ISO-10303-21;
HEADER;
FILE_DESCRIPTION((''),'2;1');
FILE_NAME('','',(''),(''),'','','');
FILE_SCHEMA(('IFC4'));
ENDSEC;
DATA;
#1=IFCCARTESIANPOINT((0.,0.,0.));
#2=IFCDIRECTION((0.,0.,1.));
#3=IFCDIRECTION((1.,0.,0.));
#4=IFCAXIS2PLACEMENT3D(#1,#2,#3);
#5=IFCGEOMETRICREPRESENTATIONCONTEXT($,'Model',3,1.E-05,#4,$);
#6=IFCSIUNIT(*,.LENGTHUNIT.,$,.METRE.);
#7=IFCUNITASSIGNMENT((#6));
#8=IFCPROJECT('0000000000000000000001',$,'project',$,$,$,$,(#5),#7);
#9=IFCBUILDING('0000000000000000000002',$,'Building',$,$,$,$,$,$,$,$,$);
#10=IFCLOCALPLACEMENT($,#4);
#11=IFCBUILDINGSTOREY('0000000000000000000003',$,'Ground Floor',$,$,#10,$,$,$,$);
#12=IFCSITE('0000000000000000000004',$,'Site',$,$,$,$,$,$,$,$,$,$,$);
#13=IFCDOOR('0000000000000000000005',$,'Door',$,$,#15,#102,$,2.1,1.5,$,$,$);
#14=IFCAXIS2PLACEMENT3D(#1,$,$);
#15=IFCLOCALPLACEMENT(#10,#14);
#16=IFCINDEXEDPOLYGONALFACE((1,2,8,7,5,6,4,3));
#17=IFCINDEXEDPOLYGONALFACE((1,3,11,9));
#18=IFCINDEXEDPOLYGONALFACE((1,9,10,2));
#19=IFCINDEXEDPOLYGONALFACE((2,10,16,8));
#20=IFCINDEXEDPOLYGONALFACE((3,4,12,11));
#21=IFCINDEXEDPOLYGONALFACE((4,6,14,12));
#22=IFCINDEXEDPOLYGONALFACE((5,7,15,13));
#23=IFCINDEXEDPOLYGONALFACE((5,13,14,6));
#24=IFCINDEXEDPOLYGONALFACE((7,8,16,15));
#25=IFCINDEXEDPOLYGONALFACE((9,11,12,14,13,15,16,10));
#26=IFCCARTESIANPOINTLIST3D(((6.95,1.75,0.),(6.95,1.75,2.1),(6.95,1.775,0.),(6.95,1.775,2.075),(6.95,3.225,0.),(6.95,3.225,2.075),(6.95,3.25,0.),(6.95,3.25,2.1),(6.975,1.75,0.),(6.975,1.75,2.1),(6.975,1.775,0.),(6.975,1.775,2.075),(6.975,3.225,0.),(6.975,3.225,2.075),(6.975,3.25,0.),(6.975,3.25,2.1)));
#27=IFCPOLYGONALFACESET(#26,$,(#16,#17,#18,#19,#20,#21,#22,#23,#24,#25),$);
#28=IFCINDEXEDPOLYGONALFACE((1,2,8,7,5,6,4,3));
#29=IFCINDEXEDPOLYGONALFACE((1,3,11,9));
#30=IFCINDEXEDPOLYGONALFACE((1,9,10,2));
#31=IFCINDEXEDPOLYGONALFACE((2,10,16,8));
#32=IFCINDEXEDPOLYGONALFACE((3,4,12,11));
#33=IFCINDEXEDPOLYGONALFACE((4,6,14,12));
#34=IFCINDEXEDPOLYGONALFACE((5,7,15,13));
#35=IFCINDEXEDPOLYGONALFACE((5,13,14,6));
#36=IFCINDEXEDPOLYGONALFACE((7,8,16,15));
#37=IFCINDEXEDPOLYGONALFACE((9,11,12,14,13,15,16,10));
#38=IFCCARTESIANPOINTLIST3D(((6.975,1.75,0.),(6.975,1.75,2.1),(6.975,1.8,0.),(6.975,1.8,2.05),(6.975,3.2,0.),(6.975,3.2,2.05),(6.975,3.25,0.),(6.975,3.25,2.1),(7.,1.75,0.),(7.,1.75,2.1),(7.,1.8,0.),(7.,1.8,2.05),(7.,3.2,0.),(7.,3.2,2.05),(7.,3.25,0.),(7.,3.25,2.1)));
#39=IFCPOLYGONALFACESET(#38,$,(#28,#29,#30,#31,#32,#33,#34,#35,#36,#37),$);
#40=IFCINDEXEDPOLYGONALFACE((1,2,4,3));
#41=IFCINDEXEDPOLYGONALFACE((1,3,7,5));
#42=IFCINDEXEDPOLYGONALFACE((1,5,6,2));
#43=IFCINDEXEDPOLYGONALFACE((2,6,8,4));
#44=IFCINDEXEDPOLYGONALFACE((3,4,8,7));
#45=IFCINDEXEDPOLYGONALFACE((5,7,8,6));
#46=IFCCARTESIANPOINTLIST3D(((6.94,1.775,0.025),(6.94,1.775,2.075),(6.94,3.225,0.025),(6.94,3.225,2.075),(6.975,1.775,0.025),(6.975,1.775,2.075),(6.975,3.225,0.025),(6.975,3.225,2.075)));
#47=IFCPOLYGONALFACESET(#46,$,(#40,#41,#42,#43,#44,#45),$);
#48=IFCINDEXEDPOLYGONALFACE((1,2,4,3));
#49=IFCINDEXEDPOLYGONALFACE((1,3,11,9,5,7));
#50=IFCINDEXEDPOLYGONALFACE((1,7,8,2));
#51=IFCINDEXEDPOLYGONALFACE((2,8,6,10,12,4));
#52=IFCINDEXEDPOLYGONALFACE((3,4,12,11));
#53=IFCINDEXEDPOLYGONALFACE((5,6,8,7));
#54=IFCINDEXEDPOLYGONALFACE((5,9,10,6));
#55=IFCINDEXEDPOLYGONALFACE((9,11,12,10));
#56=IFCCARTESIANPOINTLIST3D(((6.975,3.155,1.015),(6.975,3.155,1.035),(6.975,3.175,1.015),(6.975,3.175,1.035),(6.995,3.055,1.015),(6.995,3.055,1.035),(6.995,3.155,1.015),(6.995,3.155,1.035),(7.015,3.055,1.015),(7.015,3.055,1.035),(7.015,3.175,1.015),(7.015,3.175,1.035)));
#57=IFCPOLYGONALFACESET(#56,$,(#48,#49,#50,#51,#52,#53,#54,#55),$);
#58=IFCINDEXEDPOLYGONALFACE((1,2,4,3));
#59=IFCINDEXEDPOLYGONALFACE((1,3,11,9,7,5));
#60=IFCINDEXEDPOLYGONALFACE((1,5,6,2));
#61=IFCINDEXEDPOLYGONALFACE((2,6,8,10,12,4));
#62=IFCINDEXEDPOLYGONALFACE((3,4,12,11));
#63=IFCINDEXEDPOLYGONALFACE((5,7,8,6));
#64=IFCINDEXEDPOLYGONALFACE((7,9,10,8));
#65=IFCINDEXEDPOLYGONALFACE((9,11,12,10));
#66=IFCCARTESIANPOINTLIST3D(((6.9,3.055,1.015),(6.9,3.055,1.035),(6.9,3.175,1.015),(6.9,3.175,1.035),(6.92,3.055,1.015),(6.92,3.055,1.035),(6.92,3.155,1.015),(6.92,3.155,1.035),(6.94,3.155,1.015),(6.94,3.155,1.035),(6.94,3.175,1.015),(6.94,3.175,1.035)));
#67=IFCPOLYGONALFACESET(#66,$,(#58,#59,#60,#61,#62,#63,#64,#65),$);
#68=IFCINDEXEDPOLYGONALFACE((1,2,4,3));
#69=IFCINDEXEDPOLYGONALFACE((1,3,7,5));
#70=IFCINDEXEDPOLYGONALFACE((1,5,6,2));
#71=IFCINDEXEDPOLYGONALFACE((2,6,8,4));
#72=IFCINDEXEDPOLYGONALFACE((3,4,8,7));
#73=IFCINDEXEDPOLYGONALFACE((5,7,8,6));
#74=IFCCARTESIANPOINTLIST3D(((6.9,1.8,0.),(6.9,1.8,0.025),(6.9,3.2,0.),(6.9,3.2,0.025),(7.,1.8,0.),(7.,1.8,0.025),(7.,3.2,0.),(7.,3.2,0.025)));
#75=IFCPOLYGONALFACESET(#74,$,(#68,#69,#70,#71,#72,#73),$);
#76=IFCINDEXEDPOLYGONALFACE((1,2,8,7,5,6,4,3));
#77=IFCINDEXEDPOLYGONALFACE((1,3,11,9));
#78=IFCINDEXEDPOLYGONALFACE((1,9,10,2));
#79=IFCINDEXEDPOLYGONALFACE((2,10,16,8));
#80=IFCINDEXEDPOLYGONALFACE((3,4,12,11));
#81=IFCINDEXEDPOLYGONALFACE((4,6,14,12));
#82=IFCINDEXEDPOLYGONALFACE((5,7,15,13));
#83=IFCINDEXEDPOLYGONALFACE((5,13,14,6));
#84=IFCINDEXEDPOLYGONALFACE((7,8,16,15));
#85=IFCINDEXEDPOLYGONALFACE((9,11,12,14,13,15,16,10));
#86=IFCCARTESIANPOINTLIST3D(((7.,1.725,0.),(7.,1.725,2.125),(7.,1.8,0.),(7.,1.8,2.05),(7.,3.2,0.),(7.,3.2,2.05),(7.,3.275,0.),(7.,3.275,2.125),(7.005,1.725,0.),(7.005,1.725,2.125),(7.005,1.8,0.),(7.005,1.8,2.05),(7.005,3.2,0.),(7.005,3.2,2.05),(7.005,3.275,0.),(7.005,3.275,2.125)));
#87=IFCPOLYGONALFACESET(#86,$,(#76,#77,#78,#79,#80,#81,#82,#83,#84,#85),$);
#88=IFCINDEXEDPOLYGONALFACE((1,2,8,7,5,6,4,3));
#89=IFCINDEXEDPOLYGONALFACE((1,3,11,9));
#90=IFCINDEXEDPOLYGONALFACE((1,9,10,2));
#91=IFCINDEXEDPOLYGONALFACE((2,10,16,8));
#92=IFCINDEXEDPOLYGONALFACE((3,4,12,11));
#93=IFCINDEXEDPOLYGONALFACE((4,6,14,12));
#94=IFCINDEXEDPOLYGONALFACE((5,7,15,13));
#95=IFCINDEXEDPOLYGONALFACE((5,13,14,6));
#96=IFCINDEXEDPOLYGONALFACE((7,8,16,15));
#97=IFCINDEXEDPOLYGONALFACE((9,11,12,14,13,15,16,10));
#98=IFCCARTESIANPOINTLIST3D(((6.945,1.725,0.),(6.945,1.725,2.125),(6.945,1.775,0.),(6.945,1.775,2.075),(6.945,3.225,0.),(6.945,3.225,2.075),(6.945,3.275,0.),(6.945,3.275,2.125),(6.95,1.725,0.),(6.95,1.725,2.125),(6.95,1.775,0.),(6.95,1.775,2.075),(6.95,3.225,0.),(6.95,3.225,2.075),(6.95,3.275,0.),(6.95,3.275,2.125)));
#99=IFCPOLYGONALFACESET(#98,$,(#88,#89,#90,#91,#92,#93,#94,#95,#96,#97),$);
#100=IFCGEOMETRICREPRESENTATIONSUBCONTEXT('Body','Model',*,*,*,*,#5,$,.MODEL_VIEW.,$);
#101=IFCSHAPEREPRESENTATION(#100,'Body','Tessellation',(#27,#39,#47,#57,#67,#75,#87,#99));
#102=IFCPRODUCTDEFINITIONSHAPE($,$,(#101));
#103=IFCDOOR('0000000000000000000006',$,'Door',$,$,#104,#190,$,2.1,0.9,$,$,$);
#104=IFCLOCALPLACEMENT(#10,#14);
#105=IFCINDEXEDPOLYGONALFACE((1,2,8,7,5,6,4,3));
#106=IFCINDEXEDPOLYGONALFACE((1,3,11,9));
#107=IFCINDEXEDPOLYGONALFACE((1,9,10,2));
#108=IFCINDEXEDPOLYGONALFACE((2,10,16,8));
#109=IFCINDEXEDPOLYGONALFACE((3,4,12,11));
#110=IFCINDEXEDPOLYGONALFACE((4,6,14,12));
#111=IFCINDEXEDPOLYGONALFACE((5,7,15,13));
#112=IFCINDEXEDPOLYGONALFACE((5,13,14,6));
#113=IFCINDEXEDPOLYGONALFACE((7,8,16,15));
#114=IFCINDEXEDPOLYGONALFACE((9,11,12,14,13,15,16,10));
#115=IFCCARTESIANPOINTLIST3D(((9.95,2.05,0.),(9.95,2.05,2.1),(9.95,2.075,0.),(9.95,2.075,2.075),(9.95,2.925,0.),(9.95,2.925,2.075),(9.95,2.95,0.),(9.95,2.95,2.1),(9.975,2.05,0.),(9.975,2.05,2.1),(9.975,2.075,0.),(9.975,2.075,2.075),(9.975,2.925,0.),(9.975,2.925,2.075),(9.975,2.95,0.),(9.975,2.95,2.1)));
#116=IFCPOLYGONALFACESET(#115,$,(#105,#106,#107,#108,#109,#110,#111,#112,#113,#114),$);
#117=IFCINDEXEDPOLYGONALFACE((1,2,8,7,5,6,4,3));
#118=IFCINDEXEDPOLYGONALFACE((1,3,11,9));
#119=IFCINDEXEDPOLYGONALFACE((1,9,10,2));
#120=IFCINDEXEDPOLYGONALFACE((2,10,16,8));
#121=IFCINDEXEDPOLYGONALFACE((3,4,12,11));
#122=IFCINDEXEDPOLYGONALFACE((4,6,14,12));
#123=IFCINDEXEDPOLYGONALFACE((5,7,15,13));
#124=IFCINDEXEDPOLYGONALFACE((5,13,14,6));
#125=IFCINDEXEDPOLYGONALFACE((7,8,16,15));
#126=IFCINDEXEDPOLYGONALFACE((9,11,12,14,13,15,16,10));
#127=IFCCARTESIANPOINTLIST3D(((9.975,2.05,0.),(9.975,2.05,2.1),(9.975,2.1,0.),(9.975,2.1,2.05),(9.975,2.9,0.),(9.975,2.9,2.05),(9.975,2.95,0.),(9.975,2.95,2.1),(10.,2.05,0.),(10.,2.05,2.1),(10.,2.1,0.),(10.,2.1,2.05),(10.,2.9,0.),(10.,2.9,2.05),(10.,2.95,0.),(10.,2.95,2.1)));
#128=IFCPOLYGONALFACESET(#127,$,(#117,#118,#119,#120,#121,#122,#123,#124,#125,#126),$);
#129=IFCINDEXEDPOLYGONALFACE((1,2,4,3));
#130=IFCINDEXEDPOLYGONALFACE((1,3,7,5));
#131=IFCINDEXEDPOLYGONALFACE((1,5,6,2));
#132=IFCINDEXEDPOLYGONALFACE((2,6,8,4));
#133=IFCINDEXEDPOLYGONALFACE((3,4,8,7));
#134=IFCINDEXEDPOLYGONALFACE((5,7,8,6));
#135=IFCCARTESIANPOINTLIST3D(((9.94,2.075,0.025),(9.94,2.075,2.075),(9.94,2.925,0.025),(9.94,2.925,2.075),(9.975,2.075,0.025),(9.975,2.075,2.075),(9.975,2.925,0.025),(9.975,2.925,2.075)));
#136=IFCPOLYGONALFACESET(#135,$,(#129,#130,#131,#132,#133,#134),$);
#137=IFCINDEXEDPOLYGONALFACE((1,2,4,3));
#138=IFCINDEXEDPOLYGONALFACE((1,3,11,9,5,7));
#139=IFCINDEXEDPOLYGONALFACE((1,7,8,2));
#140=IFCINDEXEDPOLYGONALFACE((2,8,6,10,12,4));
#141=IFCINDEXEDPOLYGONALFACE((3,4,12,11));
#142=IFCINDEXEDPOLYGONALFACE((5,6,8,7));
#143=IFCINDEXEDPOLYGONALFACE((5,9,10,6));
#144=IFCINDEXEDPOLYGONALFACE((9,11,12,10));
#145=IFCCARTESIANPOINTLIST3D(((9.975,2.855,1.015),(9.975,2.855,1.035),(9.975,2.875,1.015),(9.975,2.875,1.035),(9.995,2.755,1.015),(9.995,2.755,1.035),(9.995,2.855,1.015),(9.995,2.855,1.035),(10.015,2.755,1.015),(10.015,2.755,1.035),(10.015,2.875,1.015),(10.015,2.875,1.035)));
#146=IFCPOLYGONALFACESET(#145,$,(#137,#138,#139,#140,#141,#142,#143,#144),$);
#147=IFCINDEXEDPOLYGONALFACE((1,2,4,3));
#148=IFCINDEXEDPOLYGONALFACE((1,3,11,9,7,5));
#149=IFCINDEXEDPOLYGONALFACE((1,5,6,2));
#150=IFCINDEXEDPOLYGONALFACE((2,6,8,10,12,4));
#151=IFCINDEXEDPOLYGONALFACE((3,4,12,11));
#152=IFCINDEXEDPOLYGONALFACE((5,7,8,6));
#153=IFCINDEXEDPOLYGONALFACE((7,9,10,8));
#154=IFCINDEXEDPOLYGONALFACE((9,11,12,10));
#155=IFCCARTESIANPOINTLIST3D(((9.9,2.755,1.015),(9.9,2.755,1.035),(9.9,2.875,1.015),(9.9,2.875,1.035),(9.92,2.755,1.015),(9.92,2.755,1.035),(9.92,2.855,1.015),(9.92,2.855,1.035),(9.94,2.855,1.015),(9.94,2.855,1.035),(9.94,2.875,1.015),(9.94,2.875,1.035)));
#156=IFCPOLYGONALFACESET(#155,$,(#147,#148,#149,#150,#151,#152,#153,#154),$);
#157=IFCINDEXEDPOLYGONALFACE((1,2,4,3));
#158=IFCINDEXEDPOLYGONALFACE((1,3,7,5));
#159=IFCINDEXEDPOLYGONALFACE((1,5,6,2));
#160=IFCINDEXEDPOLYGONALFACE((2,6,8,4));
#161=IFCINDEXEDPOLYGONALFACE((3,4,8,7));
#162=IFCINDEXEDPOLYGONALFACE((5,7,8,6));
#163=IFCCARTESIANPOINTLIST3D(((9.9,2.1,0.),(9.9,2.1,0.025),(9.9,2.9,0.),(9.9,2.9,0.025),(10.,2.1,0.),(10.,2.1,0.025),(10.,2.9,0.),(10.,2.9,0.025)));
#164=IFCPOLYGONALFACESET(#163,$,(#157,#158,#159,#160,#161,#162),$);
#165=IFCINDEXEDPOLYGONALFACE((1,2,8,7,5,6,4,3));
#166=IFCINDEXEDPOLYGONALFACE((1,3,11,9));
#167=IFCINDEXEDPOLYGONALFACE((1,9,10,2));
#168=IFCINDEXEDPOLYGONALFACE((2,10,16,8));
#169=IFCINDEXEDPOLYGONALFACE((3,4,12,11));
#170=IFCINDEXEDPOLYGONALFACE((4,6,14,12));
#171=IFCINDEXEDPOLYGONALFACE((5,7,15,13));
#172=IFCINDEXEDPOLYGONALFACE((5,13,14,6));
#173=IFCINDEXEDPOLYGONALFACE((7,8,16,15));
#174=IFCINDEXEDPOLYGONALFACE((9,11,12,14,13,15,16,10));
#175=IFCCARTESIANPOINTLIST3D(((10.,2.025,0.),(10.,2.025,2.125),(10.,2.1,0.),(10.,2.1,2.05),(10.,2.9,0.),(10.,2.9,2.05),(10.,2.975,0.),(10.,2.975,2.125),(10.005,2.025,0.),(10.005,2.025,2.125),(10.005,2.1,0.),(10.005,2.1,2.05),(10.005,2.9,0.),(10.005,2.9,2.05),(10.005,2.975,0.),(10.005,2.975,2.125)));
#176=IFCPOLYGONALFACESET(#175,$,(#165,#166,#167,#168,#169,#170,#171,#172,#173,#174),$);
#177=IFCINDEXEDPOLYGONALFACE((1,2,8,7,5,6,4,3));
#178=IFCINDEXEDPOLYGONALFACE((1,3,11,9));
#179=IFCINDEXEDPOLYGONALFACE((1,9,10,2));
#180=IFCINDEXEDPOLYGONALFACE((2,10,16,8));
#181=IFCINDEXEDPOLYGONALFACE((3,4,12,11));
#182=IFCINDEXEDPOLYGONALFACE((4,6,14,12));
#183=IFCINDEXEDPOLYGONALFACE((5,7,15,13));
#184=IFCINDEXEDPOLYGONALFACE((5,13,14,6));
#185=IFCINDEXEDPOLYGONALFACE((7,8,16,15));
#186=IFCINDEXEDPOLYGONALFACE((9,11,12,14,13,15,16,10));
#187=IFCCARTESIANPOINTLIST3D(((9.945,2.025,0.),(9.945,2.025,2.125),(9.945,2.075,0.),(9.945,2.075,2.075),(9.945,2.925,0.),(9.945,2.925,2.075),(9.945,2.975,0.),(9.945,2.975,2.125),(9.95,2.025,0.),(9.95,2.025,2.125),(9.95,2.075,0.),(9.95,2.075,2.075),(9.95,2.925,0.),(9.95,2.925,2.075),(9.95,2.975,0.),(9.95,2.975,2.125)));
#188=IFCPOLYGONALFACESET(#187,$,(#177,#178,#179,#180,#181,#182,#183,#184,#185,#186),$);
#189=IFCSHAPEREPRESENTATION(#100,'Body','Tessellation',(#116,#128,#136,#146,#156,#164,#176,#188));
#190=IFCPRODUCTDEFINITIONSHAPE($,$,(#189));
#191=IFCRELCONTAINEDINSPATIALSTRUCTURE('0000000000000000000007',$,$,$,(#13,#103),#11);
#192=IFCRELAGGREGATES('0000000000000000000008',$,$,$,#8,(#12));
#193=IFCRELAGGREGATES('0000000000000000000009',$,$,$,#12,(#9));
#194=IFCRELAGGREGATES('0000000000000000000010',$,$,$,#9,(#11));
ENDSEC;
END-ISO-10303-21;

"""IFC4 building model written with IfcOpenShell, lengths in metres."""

from ifc_helpers import new_model, si_unit, frame, origin_with_axes, place, context, subcontext, project, spatial, line, indexed_curve, outline, extrude, element, save


model = new_model("IFC4")

# Units and contexts
model_context = context("Model", 3, precision=1e-05, world=origin_with_axes())
body_context = subcontext(model_context, "Body", "Model", "MODEL_VIEW")
ifc_project = project(units=[si_unit("LENGTHUNIT", "METRE")], contexts=[model_context])

# Site, building, storey
site = spatial("IfcSite", under=ifc_project, Name="Site")
building = spatial("IfcBuilding", under=site, Name="Building")
storey_placement = place(None, origin_with_axes())
storey = spatial("IfcBuildingStorey", under=building, at=storey_placement, Name="Ground Floor")

# Doors
door_1_placement = place(storey_placement, frame((7.0, 1.75, 0.0), z_axis=(0.0, 0.0, 1.0), x_axis=(0.0, 1.0, 0.0)))
element("IfcDoor", 1, at=door_1_placement, inside=storey, Name="Door", OverallHeight=2.1, OverallWidth=1.5, context=body_context, shape_type="SweptSolid", body=[
    extrude(outline(indexed_curve([(0.0, 0.0), (0.0, 2.1), (1.5, 2.1), (1.5, 0.0), (1.475, 0.0), (1.475, 2.075), (0.025, 2.075), (0.025, 0.0)], segments=[line(1, 2, 3, 4, 5, 6, 7, 8, 1)])), frame((0.0, 0.025, 0.0), z_axis=(0.0, -1.0, 0.0), x_axis=(1.0, 0.0, 0.0)), (0.0, 0.0, -1.0), 0.025),
    extrude(outline(indexed_curve([(0.0, 0.0), (0.0, 2.1), (1.5, 2.1), (1.5, 0.0), (1.45, 0.0), (1.45, 2.05), (0.05, 2.05), (0.05, 0.0)], segments=[line(1, 2, 3, 4, 5, 6, 7, 8, 1)])), frame((0.0, 0.0, 0.0), z_axis=(0.0, -1.0, 0.0), x_axis=(1.0, 0.0, 0.0)), (0.0, 0.0, -1.0), 0.025),
    extrude(outline(indexed_curve([(0.0, 0.0), (1.45, 0.0), (1.45, 0.035), (0.0, 0.035)], segments=[line(1, 2, 3, 4, 1)])), frame((0.025, 0.025, 0.025), z_axis=(0.0, 0.0, 1.0), x_axis=(1.0, 0.0, 0.0)), (0.0, 0.0, 1.0), 2.05),
    extrude(outline(indexed_curve([(0.0, 0.0), (0.0, -0.04), (-0.12, -0.04), (-0.12, -0.02), (-0.02, -0.02), (-0.02, 0.0)], segments=[line(1, 2, 3, 4, 5, 6, 1)])), frame((1.425, 0.025, 1.015), z_axis=(0.0, 0.0, 1.0), x_axis=(1.0, 0.0, 0.0)), (0.0, 0.0, 1.0), 0.02),
    extrude(outline(indexed_curve([(0.0, 0.0), (0.0, 0.04), (-0.12, 0.04), (-0.12, 0.02), (-0.02, 0.02), (-0.02, 0.0)], segments=[line(1, 2, 3, 4, 5, 6, 1)])), frame((1.425, 0.06, 1.015), z_axis=(0.0, 0.0, 1.0), x_axis=(1.0, 0.0, 0.0)), (0.0, 0.0, 1.0), 0.02),
    extrude(outline(indexed_curve([(0.0, 0.0), (1.4, 0.0), (1.4, 0.1), (0.0, 0.1)], segments=[line(1, 2, 3, 4, 1)])), frame((0.05, 0.0, 0.0), z_axis=(0.0, 0.0, 1.0), x_axis=(1.0, 0.0, 0.0)), (0.0, 0.0, 1.0), 0.025),
    extrude(outline(indexed_curve([(0.0, 0.0), (0.0, 2.125), (1.55, 2.125), (1.55, 0.0), (1.475, 0.0), (1.475, 2.05), (0.075, 2.05), (0.075, 0.0)], segments=[line(1, 2, 3, 4, 5, 6, 7, 8, 1)])), frame((-0.025, -0.005, 0.0), z_axis=(0.0, -1.0, 0.0), x_axis=(1.0, 0.0, 0.0)), (0.0, 0.0, -1.0), 0.005),
    extrude(outline(indexed_curve([(0.0, 0.0), (0.0, 2.125), (1.55, 2.125), (1.55, 0.0), (1.5, 0.0), (1.5, 2.075), (0.05, 2.075), (0.05, 0.0)], segments=[line(1, 2, 3, 4, 5, 6, 7, 8, 1)])), frame((-0.025, 0.05, 0.0), z_axis=(0.0, -1.0, 0.0), x_axis=(1.0, 0.0, 0.0)), (0.0, 0.0, -1.0), 0.005),
])
door_2_placement = place(storey_placement, frame((10.0, 2.05, 0.0), z_axis=(0.0, 0.0, 1.0), x_axis=(0.0, 1.0, 0.0)))
element("IfcDoor", 2, at=door_2_placement, inside=storey, Name="Door", OverallHeight=2.1, OverallWidth=0.9, context=body_context, shape_type="SweptSolid", body=[
    extrude(outline(indexed_curve([(0.0, 0.0), (0.0, 2.1), (0.9, 2.1), (0.9, 0.0), (0.875, 0.0), (0.875, 2.075), (0.025, 2.075), (0.025, 0.0)], segments=[line(1, 2, 3, 4, 5, 6, 7, 8, 1)])), frame((0.0, 0.025, 0.0), z_axis=(0.0, -1.0, 0.0), x_axis=(1.0, 0.0, 0.0)), (0.0, 0.0, -1.0), 0.025),
    extrude(outline(indexed_curve([(0.0, 0.0), (0.0, 2.1), (0.9, 2.1), (0.9, 0.0), (0.85, 0.0), (0.85, 2.05), (0.05, 2.05), (0.05, 0.0)], segments=[line(1, 2, 3, 4, 5, 6, 7, 8, 1)])), frame((0.0, 0.0, 0.0), z_axis=(0.0, -1.0, 0.0), x_axis=(1.0, 0.0, 0.0)), (0.0, 0.0, -1.0), 0.025),
    extrude(outline(indexed_curve([(0.0, 0.0), (0.85, 0.0), (0.85, 0.035), (0.0, 0.035)], segments=[line(1, 2, 3, 4, 1)])), frame((0.025, 0.025, 0.025), z_axis=(0.0, 0.0, 1.0), x_axis=(1.0, 0.0, 0.0)), (0.0, 0.0, 1.0), 2.05),
    extrude(outline(indexed_curve([(0.0, 0.0), (0.0, -0.04), (-0.12, -0.04), (-0.12, -0.02), (-0.02, -0.02), (-0.02, 0.0)], segments=[line(1, 2, 3, 4, 5, 6, 1)])), frame((0.825, 0.025, 1.015), z_axis=(0.0, 0.0, 1.0), x_axis=(1.0, 0.0, 0.0)), (0.0, 0.0, 1.0), 0.02),
    extrude(outline(indexed_curve([(0.0, 0.0), (0.0, 0.04), (-0.12, 0.04), (-0.12, 0.02), (-0.02, 0.02), (-0.02, 0.0)], segments=[line(1, 2, 3, 4, 5, 6, 1)])), frame((0.825, 0.06, 1.015), z_axis=(0.0, 0.0, 1.0), x_axis=(1.0, 0.0, 0.0)), (0.0, 0.0, 1.0), 0.02),
    extrude(outline(indexed_curve([(0.0, 0.0), (0.8, 0.0), (0.8, 0.1), (0.0, 0.1)], segments=[line(1, 2, 3, 4, 1)])), frame((0.05, 0.0, 0.0), z_axis=(0.0, 0.0, 1.0), x_axis=(1.0, 0.0, 0.0)), (0.0, 0.0, 1.0), 0.025),
    extrude(outline(indexed_curve([(0.0, 0.0), (0.0, 2.125), (0.95, 2.125), (0.95, 0.0), (0.875, 0.0), (0.875, 2.05), (0.075, 2.05), (0.075, 0.0)], segments=[line(1, 2, 3, 4, 5, 6, 7, 8, 1)])), frame((-0.025, -0.005, 0.0), z_axis=(0.0, -1.0, 0.0), x_axis=(1.0, 0.0, 0.0)), (0.0, 0.0, -1.0), 0.005),
    extrude(outline(indexed_curve([(0.0, 0.0), (0.0, 2.125), (0.95, 2.125), (0.95, 0.0), (0.9, 0.0), (0.9, 2.075), (0.05, 2.075), (0.05, 0.0)], segments=[line(1, 2, 3, 4, 5, 6, 7, 8, 1)])), frame((-0.025, 0.05, 0.0), z_axis=(0.0, -1.0, 0.0), x_axis=(1.0, 0.0, 0.0)), (0.0, 0.0, -1.0), 0.005),
])

save(model, "model.ifc")
